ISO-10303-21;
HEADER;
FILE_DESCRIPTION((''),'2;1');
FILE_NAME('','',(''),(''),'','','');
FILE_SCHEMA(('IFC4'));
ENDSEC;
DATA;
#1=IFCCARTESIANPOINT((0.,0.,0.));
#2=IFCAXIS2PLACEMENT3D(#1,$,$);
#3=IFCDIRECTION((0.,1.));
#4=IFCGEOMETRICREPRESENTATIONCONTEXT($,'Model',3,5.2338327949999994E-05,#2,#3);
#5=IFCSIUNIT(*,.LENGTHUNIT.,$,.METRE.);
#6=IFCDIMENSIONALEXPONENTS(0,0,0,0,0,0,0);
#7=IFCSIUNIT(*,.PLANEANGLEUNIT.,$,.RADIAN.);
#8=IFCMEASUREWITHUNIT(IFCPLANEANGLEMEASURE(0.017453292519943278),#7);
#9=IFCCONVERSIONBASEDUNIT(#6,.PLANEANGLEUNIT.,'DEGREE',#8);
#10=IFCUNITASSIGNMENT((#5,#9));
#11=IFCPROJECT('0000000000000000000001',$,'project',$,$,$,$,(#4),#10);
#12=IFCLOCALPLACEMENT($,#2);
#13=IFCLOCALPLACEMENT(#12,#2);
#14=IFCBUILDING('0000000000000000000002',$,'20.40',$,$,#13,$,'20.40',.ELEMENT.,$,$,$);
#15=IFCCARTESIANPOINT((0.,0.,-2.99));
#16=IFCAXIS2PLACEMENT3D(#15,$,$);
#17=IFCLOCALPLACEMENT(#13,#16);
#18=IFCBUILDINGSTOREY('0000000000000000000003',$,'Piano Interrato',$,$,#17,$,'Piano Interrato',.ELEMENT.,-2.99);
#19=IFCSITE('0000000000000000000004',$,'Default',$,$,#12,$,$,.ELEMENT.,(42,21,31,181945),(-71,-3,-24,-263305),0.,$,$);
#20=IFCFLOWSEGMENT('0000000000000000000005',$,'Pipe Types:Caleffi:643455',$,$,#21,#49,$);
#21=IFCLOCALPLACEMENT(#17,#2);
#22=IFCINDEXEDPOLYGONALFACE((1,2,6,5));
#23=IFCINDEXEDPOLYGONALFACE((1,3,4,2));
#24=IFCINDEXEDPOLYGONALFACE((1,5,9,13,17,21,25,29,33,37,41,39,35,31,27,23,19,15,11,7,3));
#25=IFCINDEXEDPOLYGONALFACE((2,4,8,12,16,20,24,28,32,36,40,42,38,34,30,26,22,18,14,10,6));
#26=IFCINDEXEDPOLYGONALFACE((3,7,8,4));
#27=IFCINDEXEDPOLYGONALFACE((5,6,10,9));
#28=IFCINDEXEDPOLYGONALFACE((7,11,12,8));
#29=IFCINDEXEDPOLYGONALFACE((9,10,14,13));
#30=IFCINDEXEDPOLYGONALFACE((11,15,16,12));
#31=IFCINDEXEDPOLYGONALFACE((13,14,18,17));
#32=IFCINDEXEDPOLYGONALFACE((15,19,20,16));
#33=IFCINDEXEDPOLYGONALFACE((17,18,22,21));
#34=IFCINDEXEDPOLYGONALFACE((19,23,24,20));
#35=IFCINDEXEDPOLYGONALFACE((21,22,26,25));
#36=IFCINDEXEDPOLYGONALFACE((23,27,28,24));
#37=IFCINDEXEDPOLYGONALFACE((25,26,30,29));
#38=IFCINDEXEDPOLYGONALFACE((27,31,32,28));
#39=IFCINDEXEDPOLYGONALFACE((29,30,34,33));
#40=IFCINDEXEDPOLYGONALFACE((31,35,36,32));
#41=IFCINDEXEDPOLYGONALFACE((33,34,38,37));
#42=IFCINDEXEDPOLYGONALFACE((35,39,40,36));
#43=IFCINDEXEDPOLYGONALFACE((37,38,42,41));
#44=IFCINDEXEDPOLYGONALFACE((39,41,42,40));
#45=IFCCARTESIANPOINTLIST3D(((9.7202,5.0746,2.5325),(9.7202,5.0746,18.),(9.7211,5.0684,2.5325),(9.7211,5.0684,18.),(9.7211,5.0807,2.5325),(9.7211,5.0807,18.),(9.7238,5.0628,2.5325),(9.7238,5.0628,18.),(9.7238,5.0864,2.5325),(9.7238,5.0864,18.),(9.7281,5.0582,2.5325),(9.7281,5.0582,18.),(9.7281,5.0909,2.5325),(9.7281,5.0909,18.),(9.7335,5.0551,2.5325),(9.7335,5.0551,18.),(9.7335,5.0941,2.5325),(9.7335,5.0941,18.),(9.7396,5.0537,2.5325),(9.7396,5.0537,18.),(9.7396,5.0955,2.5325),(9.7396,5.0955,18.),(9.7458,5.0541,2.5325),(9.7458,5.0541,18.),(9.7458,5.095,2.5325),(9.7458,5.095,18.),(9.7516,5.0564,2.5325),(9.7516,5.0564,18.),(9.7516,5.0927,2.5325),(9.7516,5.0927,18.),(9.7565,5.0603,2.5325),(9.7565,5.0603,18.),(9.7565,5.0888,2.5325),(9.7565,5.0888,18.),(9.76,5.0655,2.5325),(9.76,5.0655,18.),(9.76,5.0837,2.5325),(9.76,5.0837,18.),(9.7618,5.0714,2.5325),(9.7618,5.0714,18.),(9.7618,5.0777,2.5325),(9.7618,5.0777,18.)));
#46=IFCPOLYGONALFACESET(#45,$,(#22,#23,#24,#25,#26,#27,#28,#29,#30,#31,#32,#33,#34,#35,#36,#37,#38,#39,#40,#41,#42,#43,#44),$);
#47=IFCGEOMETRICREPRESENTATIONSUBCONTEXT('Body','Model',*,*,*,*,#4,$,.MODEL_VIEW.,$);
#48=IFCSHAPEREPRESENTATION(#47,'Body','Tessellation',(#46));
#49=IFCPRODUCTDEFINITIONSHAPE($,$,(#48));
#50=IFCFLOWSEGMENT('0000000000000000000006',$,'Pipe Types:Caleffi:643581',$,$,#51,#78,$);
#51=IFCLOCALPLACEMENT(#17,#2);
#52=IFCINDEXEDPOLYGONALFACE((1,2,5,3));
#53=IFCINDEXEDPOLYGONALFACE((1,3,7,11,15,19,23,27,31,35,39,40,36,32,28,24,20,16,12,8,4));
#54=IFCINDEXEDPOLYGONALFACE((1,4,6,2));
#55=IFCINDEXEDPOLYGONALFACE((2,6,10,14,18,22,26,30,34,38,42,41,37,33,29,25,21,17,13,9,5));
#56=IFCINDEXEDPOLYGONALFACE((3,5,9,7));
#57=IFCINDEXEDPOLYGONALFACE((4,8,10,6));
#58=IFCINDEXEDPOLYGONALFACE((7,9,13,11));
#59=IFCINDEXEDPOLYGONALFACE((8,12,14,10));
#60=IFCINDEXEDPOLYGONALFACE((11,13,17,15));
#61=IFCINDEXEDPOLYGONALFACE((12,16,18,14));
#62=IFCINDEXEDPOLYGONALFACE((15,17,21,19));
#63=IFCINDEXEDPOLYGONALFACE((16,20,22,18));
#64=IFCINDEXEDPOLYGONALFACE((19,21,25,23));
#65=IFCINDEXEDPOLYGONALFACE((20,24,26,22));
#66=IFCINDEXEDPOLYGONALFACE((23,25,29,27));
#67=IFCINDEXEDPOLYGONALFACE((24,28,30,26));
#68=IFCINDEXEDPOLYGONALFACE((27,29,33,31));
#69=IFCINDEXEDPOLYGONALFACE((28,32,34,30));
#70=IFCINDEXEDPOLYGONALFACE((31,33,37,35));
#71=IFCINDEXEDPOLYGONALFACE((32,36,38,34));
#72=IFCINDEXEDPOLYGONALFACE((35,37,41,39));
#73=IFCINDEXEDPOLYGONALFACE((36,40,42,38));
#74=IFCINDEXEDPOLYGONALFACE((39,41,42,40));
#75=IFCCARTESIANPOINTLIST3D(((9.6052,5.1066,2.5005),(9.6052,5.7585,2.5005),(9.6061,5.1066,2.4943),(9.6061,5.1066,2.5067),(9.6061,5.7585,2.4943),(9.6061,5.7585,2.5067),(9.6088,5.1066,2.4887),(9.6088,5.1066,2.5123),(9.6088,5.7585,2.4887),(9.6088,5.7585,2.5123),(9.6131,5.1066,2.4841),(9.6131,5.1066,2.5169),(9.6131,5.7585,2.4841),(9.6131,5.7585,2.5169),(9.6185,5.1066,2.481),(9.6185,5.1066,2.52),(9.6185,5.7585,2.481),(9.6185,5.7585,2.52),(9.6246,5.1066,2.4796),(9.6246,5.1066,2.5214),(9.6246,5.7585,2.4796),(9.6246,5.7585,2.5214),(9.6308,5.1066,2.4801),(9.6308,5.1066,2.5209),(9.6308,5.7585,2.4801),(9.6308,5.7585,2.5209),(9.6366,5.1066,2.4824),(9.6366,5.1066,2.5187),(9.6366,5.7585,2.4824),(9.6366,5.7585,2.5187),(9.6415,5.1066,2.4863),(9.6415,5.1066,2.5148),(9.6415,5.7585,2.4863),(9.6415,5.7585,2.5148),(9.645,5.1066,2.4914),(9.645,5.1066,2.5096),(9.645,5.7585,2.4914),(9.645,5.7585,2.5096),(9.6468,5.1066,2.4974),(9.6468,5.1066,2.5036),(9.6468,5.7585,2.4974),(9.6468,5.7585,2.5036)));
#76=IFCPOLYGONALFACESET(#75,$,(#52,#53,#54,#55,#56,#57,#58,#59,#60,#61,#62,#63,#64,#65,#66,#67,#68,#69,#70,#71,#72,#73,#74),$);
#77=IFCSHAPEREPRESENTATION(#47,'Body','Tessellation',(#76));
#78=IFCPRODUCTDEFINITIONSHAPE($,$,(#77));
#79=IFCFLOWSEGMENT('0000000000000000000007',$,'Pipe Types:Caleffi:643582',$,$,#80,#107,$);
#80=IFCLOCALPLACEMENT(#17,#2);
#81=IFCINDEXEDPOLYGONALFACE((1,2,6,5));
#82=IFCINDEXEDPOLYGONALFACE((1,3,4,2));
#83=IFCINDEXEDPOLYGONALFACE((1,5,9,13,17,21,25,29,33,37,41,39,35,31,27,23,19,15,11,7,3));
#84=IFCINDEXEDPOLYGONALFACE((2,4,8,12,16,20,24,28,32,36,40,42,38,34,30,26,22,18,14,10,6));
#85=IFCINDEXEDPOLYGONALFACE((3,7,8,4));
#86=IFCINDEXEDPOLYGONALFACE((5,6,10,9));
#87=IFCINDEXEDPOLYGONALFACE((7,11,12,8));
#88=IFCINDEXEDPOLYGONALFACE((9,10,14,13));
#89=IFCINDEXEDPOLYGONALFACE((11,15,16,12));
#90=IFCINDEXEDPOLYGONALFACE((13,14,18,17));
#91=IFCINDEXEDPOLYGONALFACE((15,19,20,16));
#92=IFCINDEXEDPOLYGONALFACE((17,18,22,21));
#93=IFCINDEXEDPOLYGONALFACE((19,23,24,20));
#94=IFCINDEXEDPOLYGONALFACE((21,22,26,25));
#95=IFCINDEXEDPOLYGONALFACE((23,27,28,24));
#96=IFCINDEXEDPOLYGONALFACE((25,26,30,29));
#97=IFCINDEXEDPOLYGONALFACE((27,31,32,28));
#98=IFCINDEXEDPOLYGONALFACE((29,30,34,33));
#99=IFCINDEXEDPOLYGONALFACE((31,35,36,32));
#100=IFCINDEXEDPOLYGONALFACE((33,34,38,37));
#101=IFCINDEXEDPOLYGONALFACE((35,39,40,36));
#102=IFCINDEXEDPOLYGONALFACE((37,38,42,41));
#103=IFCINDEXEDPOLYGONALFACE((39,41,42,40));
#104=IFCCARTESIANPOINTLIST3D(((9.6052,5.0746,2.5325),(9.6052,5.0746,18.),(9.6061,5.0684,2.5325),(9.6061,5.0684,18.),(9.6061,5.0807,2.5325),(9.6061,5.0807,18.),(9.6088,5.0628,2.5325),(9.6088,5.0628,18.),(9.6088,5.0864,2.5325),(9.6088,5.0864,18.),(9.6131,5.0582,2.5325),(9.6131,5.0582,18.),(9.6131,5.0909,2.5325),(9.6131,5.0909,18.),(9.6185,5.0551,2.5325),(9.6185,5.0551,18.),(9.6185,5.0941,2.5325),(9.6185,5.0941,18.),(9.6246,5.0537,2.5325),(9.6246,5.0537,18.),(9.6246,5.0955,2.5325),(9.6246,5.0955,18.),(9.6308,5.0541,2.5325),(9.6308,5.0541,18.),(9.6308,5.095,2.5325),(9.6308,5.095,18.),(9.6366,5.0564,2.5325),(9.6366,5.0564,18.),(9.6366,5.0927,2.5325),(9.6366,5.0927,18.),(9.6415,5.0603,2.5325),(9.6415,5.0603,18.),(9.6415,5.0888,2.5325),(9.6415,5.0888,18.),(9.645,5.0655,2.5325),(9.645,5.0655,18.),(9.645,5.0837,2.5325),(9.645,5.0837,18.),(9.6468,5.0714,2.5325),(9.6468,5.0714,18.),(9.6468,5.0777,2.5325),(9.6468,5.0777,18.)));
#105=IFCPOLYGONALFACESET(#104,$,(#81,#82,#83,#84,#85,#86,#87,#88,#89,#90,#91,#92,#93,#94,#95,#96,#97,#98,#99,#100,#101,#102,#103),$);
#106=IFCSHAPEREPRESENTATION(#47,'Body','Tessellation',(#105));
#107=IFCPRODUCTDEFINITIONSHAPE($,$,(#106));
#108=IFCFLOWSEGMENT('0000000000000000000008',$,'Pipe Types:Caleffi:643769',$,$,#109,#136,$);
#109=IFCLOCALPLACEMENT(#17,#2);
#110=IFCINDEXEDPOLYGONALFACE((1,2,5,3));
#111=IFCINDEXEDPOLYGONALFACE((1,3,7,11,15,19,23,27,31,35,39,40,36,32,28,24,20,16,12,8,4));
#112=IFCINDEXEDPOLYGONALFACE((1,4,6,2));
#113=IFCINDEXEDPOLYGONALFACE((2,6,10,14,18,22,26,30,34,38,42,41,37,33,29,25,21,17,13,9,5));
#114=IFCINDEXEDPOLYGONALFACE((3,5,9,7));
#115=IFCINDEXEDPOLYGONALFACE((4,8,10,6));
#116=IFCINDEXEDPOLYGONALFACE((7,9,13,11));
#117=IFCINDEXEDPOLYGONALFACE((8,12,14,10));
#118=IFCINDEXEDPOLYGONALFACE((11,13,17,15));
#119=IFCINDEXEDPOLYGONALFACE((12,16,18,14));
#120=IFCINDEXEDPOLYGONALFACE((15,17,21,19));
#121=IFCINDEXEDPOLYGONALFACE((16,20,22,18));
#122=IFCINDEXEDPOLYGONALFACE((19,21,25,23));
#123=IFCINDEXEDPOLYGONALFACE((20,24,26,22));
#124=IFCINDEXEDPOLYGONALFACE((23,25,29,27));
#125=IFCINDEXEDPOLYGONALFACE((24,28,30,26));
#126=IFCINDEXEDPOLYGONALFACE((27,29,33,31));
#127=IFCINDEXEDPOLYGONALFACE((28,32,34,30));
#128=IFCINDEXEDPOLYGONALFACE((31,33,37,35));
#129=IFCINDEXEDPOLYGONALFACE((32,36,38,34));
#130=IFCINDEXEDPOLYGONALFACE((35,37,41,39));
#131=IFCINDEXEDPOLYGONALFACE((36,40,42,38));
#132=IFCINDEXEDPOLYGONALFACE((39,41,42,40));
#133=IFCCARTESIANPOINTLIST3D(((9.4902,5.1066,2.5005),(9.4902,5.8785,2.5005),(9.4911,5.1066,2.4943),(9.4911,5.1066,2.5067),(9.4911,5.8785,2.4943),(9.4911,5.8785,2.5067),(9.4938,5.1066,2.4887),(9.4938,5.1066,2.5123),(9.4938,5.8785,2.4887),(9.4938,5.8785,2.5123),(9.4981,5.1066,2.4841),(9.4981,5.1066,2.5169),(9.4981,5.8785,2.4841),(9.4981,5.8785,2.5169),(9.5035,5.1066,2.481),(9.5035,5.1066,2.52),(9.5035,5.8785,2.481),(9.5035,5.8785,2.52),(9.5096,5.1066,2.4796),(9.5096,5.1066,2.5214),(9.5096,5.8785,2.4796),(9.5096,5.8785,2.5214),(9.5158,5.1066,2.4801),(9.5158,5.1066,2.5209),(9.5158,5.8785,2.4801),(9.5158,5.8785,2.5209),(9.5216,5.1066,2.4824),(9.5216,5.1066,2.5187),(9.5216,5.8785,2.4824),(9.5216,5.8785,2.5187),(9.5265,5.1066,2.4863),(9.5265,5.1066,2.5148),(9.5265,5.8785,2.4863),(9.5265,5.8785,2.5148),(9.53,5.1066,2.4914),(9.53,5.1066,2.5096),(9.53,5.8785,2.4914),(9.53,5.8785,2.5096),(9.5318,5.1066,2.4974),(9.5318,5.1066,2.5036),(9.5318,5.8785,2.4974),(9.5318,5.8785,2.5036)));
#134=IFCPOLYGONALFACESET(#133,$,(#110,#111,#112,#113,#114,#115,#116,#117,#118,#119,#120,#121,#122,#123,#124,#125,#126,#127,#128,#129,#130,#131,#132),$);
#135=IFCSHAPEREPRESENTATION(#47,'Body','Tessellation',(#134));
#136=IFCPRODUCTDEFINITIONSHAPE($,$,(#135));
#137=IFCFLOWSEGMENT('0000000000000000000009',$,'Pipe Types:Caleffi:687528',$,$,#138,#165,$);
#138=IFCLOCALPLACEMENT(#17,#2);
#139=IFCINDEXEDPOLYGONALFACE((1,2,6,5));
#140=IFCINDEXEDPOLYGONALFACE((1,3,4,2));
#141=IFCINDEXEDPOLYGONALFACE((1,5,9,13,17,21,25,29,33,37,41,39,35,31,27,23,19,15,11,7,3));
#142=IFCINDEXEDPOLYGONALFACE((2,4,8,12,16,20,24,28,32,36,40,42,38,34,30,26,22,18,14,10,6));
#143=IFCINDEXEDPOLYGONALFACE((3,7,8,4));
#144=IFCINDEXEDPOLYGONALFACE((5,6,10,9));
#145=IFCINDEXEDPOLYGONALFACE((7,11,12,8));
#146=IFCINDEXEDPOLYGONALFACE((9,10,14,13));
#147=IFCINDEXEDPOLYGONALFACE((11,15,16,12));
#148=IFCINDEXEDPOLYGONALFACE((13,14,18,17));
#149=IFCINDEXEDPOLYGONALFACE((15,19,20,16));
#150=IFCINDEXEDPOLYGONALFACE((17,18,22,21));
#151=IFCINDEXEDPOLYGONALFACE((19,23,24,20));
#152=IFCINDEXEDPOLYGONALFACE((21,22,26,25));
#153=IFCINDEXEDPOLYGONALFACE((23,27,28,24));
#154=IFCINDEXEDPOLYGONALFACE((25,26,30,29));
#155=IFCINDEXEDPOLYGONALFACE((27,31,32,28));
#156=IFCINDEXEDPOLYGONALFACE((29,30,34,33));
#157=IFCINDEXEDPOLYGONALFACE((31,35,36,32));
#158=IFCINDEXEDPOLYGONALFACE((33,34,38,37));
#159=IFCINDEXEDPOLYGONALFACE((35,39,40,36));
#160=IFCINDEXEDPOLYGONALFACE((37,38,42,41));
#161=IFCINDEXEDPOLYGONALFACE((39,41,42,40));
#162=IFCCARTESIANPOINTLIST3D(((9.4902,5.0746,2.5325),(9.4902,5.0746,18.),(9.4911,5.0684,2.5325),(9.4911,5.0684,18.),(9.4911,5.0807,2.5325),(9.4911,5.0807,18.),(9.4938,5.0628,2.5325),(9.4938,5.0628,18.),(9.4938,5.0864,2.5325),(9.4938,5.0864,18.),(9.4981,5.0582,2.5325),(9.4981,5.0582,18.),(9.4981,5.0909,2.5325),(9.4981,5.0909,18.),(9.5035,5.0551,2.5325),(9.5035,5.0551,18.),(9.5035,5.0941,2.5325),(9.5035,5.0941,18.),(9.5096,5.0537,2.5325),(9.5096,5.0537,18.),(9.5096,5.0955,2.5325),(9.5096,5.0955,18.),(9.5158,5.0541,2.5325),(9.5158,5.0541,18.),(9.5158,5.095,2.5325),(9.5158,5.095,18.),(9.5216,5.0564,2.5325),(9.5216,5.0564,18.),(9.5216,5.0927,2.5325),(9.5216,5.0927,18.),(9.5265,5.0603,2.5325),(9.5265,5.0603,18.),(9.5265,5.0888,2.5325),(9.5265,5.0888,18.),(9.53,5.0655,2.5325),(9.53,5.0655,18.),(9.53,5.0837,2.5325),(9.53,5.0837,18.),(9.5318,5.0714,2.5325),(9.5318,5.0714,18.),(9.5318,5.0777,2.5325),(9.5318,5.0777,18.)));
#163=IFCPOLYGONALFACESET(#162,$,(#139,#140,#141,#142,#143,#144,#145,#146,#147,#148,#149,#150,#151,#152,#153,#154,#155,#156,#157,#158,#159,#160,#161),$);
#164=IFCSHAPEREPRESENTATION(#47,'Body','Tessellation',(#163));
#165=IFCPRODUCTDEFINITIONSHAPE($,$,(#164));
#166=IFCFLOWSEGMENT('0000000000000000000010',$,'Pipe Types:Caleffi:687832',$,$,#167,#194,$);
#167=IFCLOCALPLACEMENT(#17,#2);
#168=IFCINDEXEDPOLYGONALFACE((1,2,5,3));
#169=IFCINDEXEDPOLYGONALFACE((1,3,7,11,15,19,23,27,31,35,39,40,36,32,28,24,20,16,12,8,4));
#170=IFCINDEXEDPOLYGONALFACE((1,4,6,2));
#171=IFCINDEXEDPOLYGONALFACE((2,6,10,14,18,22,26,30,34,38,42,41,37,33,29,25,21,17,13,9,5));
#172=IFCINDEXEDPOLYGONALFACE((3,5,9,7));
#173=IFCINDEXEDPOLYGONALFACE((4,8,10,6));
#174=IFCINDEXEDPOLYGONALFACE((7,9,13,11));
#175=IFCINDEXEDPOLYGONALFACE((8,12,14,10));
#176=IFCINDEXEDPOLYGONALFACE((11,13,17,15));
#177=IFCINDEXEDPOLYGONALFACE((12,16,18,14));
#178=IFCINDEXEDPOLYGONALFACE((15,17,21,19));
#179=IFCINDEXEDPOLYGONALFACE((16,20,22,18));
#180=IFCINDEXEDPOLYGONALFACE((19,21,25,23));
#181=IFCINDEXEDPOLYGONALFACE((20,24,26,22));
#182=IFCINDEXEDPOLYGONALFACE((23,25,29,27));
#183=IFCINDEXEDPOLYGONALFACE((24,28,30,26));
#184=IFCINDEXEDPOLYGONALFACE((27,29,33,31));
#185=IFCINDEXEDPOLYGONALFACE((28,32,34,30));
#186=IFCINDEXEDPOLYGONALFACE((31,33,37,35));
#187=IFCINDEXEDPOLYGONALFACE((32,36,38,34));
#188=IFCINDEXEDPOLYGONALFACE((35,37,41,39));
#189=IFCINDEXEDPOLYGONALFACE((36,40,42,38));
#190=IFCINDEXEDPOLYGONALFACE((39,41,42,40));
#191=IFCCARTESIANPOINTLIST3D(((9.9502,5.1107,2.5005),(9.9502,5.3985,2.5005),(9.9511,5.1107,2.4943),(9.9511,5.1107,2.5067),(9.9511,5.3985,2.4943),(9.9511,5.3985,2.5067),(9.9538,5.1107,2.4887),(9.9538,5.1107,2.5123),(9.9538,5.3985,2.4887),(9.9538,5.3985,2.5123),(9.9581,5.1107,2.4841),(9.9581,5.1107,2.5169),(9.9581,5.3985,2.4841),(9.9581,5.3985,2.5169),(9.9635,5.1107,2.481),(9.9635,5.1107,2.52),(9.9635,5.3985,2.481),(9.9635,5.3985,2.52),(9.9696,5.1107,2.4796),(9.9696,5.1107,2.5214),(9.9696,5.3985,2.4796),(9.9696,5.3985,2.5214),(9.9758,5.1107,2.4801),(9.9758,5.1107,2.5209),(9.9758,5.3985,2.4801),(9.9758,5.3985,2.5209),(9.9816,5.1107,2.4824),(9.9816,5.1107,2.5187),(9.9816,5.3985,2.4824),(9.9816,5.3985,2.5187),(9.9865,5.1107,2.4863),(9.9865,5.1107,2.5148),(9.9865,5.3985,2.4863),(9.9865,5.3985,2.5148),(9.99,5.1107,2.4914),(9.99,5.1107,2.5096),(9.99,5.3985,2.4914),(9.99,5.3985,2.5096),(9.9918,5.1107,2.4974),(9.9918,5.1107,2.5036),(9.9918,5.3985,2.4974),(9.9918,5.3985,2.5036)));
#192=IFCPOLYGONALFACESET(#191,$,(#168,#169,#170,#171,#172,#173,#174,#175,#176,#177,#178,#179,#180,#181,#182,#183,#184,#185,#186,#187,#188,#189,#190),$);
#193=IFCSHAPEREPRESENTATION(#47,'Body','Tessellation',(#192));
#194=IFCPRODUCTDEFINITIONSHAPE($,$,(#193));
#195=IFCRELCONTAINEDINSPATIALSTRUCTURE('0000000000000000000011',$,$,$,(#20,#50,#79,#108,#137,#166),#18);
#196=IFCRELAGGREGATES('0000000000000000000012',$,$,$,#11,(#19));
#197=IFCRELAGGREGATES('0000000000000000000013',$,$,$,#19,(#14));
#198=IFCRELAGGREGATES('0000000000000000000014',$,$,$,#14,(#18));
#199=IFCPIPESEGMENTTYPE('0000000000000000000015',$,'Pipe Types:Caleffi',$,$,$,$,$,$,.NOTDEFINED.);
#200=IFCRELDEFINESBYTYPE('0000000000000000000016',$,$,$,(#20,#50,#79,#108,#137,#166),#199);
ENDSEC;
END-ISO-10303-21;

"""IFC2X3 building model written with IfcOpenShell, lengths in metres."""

from ifc_helpers import new_model, entity, si_unit, converted_unit, direction, frame, frame_2d, origin, origin_2d_with_axis, place, context, subcontext, project, spatial, circle, extrude, type_object, element, save


model = new_model("IFC2X3")

# Units and contexts
model_context = context("Model", 3, precision=5.2338327949999994e-05, world=origin(), true_north=direction((0.0, 1.0)))
body_context = subcontext(model_context, "Body", "Model", "MODEL_VIEW")
ifc_project = project(units=[si_unit("LENGTHUNIT", "METRE"), converted_unit("PLANEANGLEUNIT", "DEGREE", entity("IfcPlaneAngleMeasure", 0.017453292519943278), si_unit("PLANEANGLEUNIT", "RADIAN"), dimensions=[0, 0, 0, 0, 0, 0, 0])], contexts=[model_context])

# Site, building, storey
site_placement = place(None, origin())
site = spatial("IfcSite", under=ifc_project, at=site_placement, Name="Default", CompositionType="ELEMENT", RefLatitude=(42, 21, 31, 181945), RefLongitude=(-71, -3, -24, -263305), RefElevation=0.0)
building_placement = place(site_placement, origin())
building = spatial("IfcBuilding", under=site, at=building_placement, Name="20.40", LongName="20.40", CompositionType="ELEMENT")
storey_placement = place(building_placement, frame((0.0, 0.0, -2.99)))
storey = spatial("IfcBuildingStorey", under=building, at=storey_placement, Name="Piano Interrato", LongName="Piano Interrato", CompositionType="ELEMENT", Elevation=-2.99)

# Flow segments
pipe_segment_type = type_object("IfcPipeSegmentType", Name="Pipe Types:Caleffi", PredefinedType="NOTDEFINED")
flow_segment_1_placement = place(storey_placement, origin())
element("IfcFlowSegment", 1, at=flow_segment_1_placement, inside=storey, type_object=pipe_segment_type, Name="Pipe Types:Caleffi:643455", context=body_context, shape_type="SweptSolid", body=[
    extrude(circle(Radius=0.0209, at=origin_2d_with_axis()), frame((9.7411, 5.0746, 2.5325), z_axis=(0.0, 0.0, 1.0), x_axis=(-1.0, 0.0, 0.0)), (0.0, 0.0, 1.0), 15.4675),
])
flow_segment_2_placement = place(storey_placement, origin())
element("IfcFlowSegment", 2, at=flow_segment_2_placement, inside=storey, type_object=pipe_segment_type, Name="Pipe Types:Caleffi:643581", context=body_context, shape_type="SweptSolid", body=[
    extrude(circle(Radius=0.0209, at=frame_2d((0.0, 0.0), x_axis=(1.0, 0.0))), frame((9.6261, 5.1066, 2.5005), z_axis=(0.0, 1.0, 0.0), x_axis=(-1.0, 0.0, 0.0)), (0.0, 0.0, 1.0), 0.6519),
])
flow_segment_3_placement = place(storey_placement, origin())
element("IfcFlowSegment", 3, at=flow_segment_3_placement, inside=storey, type_object=pipe_segment_type, Name="Pipe Types:Caleffi:643582", context=body_context, shape_type="SweptSolid", body=[
    extrude(circle(Radius=0.0209, at=origin_2d_with_axis()), frame((9.6261, 5.0746, 2.5325), z_axis=(0.0, 0.0, 1.0), x_axis=(-1.0, 0.0, 0.0)), (0.0, 0.0, 1.0), 15.4675),
])
flow_segment_4_placement = place(storey_placement, origin())
element("IfcFlowSegment", 4, at=flow_segment_4_placement, inside=storey, type_object=pipe_segment_type, Name="Pipe Types:Caleffi:643769", context=body_context, shape_type="SweptSolid", body=[
    extrude(circle(Radius=0.0209, at=frame_2d((0.0, 0.0), x_axis=(1.0, 0.0))), frame((9.5111, 5.1066, 2.5005), z_axis=(0.0, 1.0, 0.0), x_axis=(-1.0, 0.0, 0.0)), (0.0, 0.0, 1.0), 0.7719),
])
flow_segment_5_placement = place(storey_placement, origin())
element("IfcFlowSegment", 5, at=flow_segment_5_placement, inside=storey, type_object=pipe_segment_type, Name="Pipe Types:Caleffi:687528", context=body_context, shape_type="SweptSolid", body=[
    extrude(circle(Radius=0.0209, at=origin_2d_with_axis()), frame((9.5111, 5.0746, 2.5325), z_axis=(0.0, 0.0, 1.0), x_axis=(-1.0, 0.0, 0.0)), (0.0, 0.0, 1.0), 15.4675),
])
flow_segment_6_placement = place(storey_placement, origin())
element("IfcFlowSegment", 6, at=flow_segment_6_placement, inside=storey, type_object=pipe_segment_type, Name="Pipe Types:Caleffi:687832", context=body_context, shape_type="SweptSolid", body=[
    extrude(circle(Radius=0.0209, at=frame_2d((0.0, 0.0), x_axis=(1.0, 0.0))), frame((9.9711, 5.1107, 2.5005), z_axis=(0.0, 1.0, 0.0), x_axis=(-1.0, 0.0, 0.0)), (0.0, 0.0, 1.0), 0.2878),
])

save(model, "model.ifc")
